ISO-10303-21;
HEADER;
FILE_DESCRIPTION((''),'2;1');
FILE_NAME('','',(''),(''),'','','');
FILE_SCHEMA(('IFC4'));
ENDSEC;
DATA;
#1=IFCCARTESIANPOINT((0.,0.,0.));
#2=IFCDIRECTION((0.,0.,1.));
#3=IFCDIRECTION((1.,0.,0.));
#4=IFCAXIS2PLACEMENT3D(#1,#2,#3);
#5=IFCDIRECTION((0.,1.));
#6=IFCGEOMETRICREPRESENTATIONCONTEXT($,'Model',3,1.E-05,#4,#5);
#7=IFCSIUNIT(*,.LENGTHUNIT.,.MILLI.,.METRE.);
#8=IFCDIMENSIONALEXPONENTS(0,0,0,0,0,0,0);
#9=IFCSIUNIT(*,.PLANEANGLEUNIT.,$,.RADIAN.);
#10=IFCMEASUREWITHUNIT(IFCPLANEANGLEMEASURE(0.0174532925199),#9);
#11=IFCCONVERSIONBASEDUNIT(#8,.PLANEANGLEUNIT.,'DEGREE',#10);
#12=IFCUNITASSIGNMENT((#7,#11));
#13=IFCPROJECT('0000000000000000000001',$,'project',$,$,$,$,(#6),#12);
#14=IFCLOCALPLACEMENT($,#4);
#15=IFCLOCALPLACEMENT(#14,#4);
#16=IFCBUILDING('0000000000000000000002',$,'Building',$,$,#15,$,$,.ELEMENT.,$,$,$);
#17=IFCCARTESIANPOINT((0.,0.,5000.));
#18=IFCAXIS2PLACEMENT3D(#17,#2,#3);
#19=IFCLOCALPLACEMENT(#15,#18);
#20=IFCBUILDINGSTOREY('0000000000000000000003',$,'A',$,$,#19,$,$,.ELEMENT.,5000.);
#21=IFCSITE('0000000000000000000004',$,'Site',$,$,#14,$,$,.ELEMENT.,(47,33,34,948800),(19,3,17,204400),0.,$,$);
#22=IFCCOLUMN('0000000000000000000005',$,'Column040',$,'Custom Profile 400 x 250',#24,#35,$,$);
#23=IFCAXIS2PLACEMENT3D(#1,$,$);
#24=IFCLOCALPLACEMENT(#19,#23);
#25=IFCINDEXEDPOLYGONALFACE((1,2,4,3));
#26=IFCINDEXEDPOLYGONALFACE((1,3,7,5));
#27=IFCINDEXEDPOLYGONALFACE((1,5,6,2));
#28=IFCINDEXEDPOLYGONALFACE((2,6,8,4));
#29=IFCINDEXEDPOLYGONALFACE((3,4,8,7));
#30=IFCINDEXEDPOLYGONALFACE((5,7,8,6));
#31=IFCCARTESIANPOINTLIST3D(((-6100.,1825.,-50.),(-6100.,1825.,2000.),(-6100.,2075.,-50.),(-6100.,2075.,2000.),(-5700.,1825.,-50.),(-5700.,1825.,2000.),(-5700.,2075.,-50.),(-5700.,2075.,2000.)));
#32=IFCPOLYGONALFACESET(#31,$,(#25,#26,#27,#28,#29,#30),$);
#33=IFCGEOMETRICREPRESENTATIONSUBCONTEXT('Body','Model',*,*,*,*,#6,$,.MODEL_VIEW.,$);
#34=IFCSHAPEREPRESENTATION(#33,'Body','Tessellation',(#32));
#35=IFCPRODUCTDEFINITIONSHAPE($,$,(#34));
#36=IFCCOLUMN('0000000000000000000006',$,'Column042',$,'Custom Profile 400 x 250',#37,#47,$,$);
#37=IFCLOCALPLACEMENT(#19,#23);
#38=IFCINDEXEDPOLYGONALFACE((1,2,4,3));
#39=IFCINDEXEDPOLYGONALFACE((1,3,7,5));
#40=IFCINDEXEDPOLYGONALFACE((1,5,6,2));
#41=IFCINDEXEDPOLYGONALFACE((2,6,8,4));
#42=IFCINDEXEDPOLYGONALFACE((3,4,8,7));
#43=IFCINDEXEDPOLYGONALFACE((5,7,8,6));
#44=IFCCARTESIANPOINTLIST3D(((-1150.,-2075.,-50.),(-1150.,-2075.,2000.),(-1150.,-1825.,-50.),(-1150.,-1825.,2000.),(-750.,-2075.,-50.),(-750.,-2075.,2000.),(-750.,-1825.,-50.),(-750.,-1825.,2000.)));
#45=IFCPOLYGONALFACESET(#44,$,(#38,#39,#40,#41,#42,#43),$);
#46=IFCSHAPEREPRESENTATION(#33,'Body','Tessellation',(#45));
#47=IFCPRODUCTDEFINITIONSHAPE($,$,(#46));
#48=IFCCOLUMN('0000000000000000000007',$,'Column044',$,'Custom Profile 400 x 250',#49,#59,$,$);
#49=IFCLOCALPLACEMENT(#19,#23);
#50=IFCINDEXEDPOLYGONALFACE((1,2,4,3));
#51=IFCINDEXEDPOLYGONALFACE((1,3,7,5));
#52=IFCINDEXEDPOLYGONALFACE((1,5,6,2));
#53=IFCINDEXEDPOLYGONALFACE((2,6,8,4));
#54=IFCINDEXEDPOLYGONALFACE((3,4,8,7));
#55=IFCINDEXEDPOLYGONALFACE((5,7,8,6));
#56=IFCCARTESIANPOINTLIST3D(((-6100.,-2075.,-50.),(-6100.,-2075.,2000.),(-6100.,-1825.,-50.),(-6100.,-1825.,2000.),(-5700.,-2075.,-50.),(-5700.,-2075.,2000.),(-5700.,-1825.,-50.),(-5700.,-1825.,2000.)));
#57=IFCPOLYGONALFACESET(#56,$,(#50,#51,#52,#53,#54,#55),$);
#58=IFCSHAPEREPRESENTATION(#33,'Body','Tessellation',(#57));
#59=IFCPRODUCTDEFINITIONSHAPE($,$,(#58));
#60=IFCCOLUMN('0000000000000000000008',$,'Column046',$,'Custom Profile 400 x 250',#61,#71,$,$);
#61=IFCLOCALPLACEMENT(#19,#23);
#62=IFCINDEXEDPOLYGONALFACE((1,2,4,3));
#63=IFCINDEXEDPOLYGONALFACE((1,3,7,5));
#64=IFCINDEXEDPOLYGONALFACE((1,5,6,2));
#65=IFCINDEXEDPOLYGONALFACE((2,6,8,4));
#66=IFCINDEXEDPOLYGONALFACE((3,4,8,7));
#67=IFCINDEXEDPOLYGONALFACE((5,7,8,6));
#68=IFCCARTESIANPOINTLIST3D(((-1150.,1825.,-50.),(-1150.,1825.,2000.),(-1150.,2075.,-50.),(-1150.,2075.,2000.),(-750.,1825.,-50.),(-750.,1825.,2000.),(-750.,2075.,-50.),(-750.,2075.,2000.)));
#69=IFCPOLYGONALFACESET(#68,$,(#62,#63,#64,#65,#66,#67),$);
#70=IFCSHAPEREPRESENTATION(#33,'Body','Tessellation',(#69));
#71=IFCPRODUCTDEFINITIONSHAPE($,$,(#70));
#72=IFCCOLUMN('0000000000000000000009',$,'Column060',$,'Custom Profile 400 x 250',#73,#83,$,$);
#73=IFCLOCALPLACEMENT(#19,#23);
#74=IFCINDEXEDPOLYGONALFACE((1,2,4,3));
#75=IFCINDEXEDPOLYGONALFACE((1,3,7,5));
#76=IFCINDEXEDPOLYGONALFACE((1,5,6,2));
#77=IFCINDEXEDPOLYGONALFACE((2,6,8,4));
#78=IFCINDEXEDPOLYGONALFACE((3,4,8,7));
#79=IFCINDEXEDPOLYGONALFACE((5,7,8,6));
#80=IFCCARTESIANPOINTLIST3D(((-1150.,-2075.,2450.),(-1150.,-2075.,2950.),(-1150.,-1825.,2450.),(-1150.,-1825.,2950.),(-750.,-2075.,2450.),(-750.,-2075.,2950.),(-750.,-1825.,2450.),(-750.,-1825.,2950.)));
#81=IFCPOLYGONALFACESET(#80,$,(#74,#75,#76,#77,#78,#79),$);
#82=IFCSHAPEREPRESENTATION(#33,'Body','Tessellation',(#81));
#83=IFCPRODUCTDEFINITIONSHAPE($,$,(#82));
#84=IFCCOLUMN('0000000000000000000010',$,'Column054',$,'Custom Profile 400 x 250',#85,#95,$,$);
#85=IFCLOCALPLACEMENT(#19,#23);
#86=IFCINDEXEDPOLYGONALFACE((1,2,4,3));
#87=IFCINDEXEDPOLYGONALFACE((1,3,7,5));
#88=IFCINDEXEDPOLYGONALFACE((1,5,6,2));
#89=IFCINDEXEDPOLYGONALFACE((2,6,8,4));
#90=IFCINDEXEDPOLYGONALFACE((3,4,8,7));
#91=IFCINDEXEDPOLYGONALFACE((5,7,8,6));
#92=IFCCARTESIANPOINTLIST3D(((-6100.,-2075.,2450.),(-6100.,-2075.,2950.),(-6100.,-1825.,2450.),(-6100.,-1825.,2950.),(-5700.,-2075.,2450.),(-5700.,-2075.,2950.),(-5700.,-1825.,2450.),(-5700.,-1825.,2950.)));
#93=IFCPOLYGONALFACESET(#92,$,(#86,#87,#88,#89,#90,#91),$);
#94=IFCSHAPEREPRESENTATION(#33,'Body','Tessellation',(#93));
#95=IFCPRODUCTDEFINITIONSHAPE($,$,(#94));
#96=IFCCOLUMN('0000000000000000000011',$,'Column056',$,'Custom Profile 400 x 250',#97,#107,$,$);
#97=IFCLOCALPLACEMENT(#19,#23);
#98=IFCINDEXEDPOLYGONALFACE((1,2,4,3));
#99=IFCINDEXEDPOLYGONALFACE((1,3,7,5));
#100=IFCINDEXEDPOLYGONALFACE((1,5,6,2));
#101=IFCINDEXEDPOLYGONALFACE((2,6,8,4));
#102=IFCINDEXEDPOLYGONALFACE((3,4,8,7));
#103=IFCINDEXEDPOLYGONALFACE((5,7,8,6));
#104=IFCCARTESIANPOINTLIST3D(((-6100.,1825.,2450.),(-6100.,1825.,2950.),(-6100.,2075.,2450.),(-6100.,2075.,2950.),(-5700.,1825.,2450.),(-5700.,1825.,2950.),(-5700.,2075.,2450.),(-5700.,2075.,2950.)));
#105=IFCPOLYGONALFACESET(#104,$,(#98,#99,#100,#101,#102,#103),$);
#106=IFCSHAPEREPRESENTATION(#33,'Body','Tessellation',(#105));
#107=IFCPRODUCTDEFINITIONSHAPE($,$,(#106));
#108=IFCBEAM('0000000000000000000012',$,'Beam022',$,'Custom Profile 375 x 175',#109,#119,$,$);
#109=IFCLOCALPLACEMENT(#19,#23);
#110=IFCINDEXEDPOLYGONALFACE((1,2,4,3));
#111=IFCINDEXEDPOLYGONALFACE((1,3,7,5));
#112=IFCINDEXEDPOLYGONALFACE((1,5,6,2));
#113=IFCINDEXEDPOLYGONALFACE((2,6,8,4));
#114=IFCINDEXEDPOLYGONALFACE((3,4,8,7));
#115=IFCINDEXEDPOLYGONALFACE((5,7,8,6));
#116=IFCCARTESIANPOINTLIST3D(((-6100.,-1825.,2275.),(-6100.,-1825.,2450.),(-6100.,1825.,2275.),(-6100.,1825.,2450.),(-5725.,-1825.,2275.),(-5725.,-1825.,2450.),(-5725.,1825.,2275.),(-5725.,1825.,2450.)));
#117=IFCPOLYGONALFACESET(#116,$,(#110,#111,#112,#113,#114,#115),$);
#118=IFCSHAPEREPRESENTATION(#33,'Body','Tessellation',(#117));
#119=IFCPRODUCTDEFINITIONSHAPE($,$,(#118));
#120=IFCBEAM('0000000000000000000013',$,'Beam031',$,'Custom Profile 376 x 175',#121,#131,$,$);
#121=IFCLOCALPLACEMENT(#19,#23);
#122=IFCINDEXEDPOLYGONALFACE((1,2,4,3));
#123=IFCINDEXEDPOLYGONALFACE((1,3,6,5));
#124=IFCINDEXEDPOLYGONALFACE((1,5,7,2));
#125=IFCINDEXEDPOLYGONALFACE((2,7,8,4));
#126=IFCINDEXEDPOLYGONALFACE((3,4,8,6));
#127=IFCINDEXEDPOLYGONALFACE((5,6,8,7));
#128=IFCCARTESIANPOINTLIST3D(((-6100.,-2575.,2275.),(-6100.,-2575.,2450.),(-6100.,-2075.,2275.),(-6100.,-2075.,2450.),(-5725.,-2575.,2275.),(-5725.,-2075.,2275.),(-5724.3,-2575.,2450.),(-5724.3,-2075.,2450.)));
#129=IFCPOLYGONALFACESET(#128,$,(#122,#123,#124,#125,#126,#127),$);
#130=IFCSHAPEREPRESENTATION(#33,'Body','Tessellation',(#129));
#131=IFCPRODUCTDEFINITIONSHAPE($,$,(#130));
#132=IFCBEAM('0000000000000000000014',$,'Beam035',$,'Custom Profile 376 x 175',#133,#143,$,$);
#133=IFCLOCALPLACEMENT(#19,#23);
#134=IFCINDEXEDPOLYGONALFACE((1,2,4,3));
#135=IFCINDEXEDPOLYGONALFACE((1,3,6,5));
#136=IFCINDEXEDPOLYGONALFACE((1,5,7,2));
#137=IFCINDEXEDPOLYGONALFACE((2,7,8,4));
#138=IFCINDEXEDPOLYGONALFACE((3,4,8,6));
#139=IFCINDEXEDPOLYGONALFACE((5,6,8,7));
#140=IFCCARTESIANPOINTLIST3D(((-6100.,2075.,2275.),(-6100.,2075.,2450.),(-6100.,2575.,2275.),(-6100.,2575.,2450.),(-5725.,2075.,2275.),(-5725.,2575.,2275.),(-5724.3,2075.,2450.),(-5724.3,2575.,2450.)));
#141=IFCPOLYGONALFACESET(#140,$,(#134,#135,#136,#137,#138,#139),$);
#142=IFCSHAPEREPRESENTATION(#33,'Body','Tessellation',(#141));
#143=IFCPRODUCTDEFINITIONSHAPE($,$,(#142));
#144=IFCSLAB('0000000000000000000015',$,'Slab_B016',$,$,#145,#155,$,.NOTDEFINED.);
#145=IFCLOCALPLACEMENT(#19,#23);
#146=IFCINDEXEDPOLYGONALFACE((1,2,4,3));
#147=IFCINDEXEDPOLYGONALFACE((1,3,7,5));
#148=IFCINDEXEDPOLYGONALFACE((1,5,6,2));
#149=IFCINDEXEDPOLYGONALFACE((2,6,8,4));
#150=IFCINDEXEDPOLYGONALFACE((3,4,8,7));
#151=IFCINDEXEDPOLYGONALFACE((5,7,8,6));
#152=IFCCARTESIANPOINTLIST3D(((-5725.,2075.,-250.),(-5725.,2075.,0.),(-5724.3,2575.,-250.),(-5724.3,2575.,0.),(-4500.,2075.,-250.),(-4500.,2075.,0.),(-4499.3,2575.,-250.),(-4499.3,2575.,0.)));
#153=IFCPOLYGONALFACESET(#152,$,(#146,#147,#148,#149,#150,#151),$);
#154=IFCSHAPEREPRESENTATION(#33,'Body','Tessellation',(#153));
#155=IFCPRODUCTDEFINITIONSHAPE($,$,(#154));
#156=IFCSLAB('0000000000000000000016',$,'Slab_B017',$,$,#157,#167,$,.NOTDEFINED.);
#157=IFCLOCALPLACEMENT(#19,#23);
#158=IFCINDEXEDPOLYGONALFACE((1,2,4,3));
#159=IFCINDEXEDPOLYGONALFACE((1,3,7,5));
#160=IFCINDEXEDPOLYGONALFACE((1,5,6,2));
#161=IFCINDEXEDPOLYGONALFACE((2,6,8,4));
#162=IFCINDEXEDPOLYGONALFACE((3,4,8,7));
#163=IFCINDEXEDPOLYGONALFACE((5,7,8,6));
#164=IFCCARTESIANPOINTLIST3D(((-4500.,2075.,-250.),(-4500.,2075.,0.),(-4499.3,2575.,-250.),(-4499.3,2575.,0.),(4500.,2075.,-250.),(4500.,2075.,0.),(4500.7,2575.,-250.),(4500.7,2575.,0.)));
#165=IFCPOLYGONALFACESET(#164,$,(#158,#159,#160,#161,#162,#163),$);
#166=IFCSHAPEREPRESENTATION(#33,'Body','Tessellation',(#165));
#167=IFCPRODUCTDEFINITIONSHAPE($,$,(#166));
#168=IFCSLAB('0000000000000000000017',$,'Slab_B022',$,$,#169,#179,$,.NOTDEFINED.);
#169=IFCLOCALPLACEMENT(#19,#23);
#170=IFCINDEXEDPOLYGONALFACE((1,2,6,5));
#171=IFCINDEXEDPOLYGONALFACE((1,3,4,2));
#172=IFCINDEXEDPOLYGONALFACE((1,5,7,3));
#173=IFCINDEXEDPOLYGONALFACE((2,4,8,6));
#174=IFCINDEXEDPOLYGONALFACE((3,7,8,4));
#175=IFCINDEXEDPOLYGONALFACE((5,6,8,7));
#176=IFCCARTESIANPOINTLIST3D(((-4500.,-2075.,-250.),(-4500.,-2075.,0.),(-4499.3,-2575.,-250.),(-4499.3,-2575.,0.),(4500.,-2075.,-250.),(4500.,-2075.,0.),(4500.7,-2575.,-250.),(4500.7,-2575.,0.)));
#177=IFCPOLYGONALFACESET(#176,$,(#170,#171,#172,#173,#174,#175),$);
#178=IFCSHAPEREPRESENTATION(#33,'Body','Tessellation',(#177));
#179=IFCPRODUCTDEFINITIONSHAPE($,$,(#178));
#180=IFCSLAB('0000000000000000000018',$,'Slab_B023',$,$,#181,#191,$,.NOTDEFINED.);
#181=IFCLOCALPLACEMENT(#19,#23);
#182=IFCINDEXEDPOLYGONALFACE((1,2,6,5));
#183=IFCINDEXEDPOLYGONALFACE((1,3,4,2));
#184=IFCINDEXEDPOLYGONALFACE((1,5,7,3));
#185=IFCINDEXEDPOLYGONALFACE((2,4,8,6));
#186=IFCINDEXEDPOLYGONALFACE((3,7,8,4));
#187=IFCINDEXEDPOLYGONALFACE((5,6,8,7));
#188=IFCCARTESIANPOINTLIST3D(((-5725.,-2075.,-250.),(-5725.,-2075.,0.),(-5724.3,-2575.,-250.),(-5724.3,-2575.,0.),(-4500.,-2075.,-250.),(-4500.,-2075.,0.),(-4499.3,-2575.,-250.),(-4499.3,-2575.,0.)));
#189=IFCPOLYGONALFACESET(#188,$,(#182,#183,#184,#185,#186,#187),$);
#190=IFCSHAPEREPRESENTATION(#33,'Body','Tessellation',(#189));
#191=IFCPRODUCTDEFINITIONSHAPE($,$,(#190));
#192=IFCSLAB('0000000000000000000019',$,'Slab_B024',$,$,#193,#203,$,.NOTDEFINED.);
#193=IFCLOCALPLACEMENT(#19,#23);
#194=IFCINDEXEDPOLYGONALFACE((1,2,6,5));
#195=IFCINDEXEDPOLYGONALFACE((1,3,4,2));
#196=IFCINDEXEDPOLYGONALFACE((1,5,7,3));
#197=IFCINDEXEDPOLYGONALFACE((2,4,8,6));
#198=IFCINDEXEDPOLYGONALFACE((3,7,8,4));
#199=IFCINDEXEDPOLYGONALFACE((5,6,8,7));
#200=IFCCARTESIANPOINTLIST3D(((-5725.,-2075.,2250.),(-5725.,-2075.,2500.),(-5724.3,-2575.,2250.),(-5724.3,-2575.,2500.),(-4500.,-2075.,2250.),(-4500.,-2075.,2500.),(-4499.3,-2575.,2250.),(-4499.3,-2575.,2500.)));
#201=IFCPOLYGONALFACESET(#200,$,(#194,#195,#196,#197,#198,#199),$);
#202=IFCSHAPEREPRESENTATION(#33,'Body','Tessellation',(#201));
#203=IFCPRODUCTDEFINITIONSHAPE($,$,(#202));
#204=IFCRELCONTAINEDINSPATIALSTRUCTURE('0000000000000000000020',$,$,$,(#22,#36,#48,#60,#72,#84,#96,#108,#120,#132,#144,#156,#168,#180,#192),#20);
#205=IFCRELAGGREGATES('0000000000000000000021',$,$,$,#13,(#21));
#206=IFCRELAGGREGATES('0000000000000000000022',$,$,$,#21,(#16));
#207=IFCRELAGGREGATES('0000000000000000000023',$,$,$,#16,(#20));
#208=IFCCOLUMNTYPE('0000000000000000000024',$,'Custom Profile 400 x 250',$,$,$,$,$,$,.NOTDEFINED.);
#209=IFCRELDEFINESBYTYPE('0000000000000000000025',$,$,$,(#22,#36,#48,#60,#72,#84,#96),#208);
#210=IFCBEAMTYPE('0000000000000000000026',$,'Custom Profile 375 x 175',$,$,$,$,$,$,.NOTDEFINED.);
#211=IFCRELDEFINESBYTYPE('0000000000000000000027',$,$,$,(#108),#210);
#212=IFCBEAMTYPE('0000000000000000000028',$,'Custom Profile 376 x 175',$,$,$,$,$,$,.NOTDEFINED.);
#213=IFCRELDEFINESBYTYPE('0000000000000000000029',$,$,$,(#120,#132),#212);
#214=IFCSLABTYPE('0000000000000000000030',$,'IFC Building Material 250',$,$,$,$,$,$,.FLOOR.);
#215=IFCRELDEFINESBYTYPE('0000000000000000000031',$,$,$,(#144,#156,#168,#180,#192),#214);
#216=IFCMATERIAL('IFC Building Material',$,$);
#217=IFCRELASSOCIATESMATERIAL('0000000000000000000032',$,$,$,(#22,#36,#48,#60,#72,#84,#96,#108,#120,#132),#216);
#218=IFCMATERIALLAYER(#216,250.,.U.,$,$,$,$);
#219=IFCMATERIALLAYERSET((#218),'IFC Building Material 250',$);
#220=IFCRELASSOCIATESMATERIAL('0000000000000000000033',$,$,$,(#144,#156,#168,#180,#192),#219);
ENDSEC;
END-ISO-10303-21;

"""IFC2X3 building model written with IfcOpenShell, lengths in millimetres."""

from ifc_helpers import new_model, entity, si_unit, converted_unit, direction, frame, origin_with_axes, place, context, subcontext, project, spatial, polyline, outline, extrude, material, layer, layer_set, layer_usage, type_object, element, save


model = new_model("IFC2X3")

# Units and contexts
model_context = context("Model", 3, precision=1e-05, world=origin_with_axes(), true_north=direction((0.0, 1.0)))
body_context = subcontext(model_context, "Body", "Model", "MODEL_VIEW")
ifc_project = project(units=[si_unit("LENGTHUNIT", "METRE", prefix="MILLI"), converted_unit("PLANEANGLEUNIT", "DEGREE", entity("IfcPlaneAngleMeasure", 0.0174532925199), si_unit("PLANEANGLEUNIT", "RADIAN"), dimensions=[0, 0, 0, 0, 0, 0, 0])], contexts=[model_context])

# Site, building, storey
site_placement = place(None, origin_with_axes())
site = spatial("IfcSite", under=ifc_project, at=site_placement, Name="Site", CompositionType="ELEMENT", RefLatitude=(47, 33, 34, 948800), RefLongitude=(19, 3, 17, 204400), RefElevation=0.0)
building_placement = place(site_placement, origin_with_axes())
building = spatial("IfcBuilding", under=site, at=building_placement, Name="Building", CompositionType="ELEMENT")
storey_placement = place(building_placement, frame((0.0, 0.0, 5000.0), z_axis=(0.0, 0.0, 1.0), x_axis=(1.0, 0.0, 0.0)))
storey = spatial("IfcBuildingStorey", under=building, at=storey_placement, Name="A", CompositionType="ELEMENT", Elevation=5000.0)

# Columns
ifc_material = material(Name="IFC Building Material")
column_type = type_object("IfcColumnType", Name="Custom Profile 400 x 250", PredefinedType="NOTDEFINED")
for number, where, z_axis, x_axis, name in (
    (1, (-5900.0, 1950.0, -50.0), (0.0, 0.0, 1.0), (1.0, 0.0, 0.0), "Column040"),
    (2, (-950.0, -1950.0, -50.0), (0.0, 0.0, 1.0), (1.0, 0.0, 0.0), "Column042"),
    (3, (-5900.0, -1950.0, -50.0), (0.0, 0.0, 1.0), (1.0, 0.0, 0.0), "Column044"),
    (4, (-950.0, 1950.0, -50.0), (0.0, 0.0, 1.0), (1.0, 0.0, 0.0), "Column046"),
):
    element("IfcColumn", number, at=place(storey_placement, frame(where, z_axis=z_axis, x_axis=x_axis)), inside=storey, type_object=column_type, material=ifc_material, Name=name, ObjectType="Custom Profile 400 x 250", context=body_context, shape_type="SweptSolid", body=[
        extrude(outline(polyline([(-200.0, -125.0), (200.0, -125.0), (200.0, 125.0), (-200.0, 125.0), (-200.0, -125.0)])), origin_with_axes(), (0.0, 0.0, 1.0), 2050.0),
    ])
for number, where, z_axis, x_axis, name in (
    (5, (-950.0, -1950.0, 2450.0), (0.0, 0.0, 1.0), (1.0, 0.0, 0.0), "Column060"),
    (6, (-5900.0, -1950.0, 2450.0), (0.0, 0.0, 1.0), (1.0, 0.0, 0.0), "Column054"),
    (7, (-5900.0, 1950.0, 2450.0), (0.0, 0.0, 1.0), (1.0, 0.0, 0.0), "Column056"),
):
    element("IfcColumn", number, at=place(storey_placement, frame(where, z_axis=z_axis, x_axis=x_axis)), inside=storey, type_object=column_type, material=ifc_material, Name=name, ObjectType="Custom Profile 400 x 250", context=body_context, shape_type="SweptSolid", body=[
        extrude(outline(polyline([(-200.0, -125.0), (200.0, -125.0), (200.0, 125.0), (-200.0, 125.0), (-200.0, -125.0)])), origin_with_axes(), (0.0, 0.0, 1.0), 500.0),
    ])

# Beams
beam_type_1 = type_object("IfcBeamType", Name="Custom Profile 375 x 175", PredefinedType="NOTDEFINED")
beam_placement = place(storey_placement, frame((-5912.3, -1825.0, 2362.5), z_axis=(0.0, 0.0, 1.0), x_axis=(1.0, 0.0, 0.0)))
element("IfcBeam", 8, at=beam_placement, inside=storey, type_object=beam_type_1, material=ifc_material, Name="Beam022", ObjectType="Custom Profile 375 x 175", context=body_context, shape_type="SweptSolid", body=[
    extrude(outline(polyline([(-187.7, -87.5), (187.3, -87.5), (187.3, 87.5), (-187.7, 87.5), (-187.7, -87.5)])), frame((0.0, 3650.0, 0.0), z_axis=(0.0, -1.0, 0.0), x_axis=(1.0, 0.0, 0.0)), (0.0, 0.0, 1.0), 3650.0),
])
beam_type_2 = type_object("IfcBeamType", Name="Custom Profile 376 x 175", PredefinedType="NOTDEFINED")
for number, where, z_axis, x_axis, name in (
    (9, (-5912.3, -2575.0, 2362.5), (0.0, 0.0, 1.0), (1.0, 0.0, 0.0), "Beam031"),
    (10, (-5912.3, 2075.0, 2362.5), (0.0, 0.0, 1.0), (1.0, 0.0, 0.0), "Beam035"),
):
    element("IfcBeam", number, at=place(storey_placement, frame(where, z_axis=z_axis, x_axis=x_axis)), inside=storey, type_object=beam_type_2, material=ifc_material, Name=name, ObjectType="Custom Profile 376 x 175", context=body_context, shape_type="SweptSolid", body=[
        extrude(outline(polyline([(-187.7, -87.5), (187.3, -87.5), (188.0, 87.5), (-187.7, 87.5), (-187.7, -87.5)])), frame((0.0, 500.0, 0.0), z_axis=(0.0, -1.0, 0.0), x_axis=(1.0, 0.0, 0.0)), (0.0, 0.0, 1.0), 500.0),
    ])

# Slabs
ifc_layer_1 = layer(ifc_material, 250.0, ventilated="UNKNOWN")
ifc_layer_set_1 = layer_set([ifc_layer_1], Name="IFC Building Material 250")
ifc_layer_usage_1 = layer_usage(ifc_layer_set_1, "AXIS3", "NEGATIVE", 250.0)
slab_type_1 = type_object("IfcSlabType", Name="IFC Building Material 250", PredefinedType="FLOOR")
slab_1_placement = place(storey_placement, frame((-5724.3, 2575.0, 0.0), z_axis=(0.0, 0.0, 1.0), x_axis=(1.0, 0.0, 0.0)))
element("IfcSlab", 11, at=slab_1_placement, inside=storey, type_object=slab_type_1, material=ifc_layer_usage_1, Name="Slab_B016", PredefinedType="NOTDEFINED", context=body_context, shape_type="SweptSolid", body=[
    extrude(outline(polyline([(0.0, 0.0), (-0.7, -500.0), (1224.3, -500.0), (1225.0, 0.0), (0.0, 0.0)])), frame((0.0, 0.0, -250.0), z_axis=(0.0, 0.0, 1.0), x_axis=(1.0, 0.0, 0.0)), (0.0, 0.0, 1.0), 250.0),
])
ifc_layer_usage_2 = layer_usage(ifc_layer_set_1, "AXIS3", "NEGATIVE", 250.0)
slab_2_placement = place(storey_placement, frame((-4499.3, 2575.0, 0.0), z_axis=(0.0, 0.0, 1.0), x_axis=(1.0, 0.0, 0.0)))
element("IfcSlab", 12, at=slab_2_placement, inside=storey, type_object=slab_type_1, material=ifc_layer_usage_2, Name="Slab_B017", PredefinedType="NOTDEFINED", context=body_context, shape_type="SweptSolid", body=[
    extrude(outline(polyline([(0.0, 0.0), (-0.7, -500.0), (8999.3, -500.0), (9000.0, 0.0), (0.0, 0.0)])), frame((0.0, 0.0, -250.0), z_axis=(0.0, 0.0, 1.0), x_axis=(1.0, 0.0, 0.0)), (0.0, 0.0, 1.0), 250.0),
])
ifc_layer_usage_3 = layer_usage(ifc_layer_set_1, "AXIS3", "NEGATIVE", 250.0)
slab_3_placement = place(storey_placement, frame((-4499.3, -2575.0, 0.0), z_axis=(0.0, 0.0, 1.0), x_axis=(1.0, 0.0, 0.0)))
element("IfcSlab", 13, at=slab_3_placement, inside=storey, type_object=slab_type_1, material=ifc_layer_usage_3, Name="Slab_B022", PredefinedType="NOTDEFINED", context=body_context, shape_type="SweptSolid", body=[
    extrude(outline(polyline([(0.0, 0.0), (9000.0, 0.0), (8999.3, 500.0), (-0.7, 500.0), (0.0, 0.0)])), frame((0.0, 0.0, -250.0), z_axis=(0.0, 0.0, 1.0), x_axis=(1.0, 0.0, 0.0)), (0.0, 0.0, 1.0), 250.0),
])
ifc_layer_usage_4 = layer_usage(ifc_layer_set_1, "AXIS3", "NEGATIVE", 250.0)
slab_4_placement = place(storey_placement, frame((-5724.3, -2575.0, 0.0), z_axis=(0.0, 0.0, 1.0), x_axis=(1.0, 0.0, 0.0)))
element("IfcSlab", 14, at=slab_4_placement, inside=storey, type_object=slab_type_1, material=ifc_layer_usage_4, Name="Slab_B023", PredefinedType="NOTDEFINED", context=body_context, shape_type="SweptSolid", body=[
    extrude(outline(polyline([(0.0, 0.0), (1225.0, 0.0), (1224.3, 500.0), (-0.7, 500.0), (0.0, 0.0)])), frame((0.0, 0.0, -250.0), z_axis=(0.0, 0.0, 1.0), x_axis=(1.0, 0.0, 0.0)), (0.0, 0.0, 1.0), 250.0),
])
ifc_layer_usage_5 = layer_usage(ifc_layer_set_1, "AXIS3", "NEGATIVE", 250.0)
slab_5_placement = place(storey_placement, frame((-5724.3, -2575.0, 2500.0), z_axis=(0.0, 0.0, 1.0), x_axis=(1.0, 0.0, 0.0)))
element("IfcSlab", 15, at=slab_5_placement, inside=storey, type_object=slab_type_1, material=ifc_layer_usage_5, Name="Slab_B024", PredefinedType="NOTDEFINED", context=body_context, shape_type="SweptSolid", body=[
    extrude(outline(polyline([(0.0, 0.0), (1225.0, 0.0), (1224.3, 500.0), (-0.7, 500.0), (0.0, 0.0)])), frame((0.0, 0.0, -250.0), z_axis=(0.0, 0.0, 1.0), x_axis=(1.0, 0.0, 0.0)), (0.0, 0.0, 1.0), 250.0),
])

save(model, "model.ifc")
